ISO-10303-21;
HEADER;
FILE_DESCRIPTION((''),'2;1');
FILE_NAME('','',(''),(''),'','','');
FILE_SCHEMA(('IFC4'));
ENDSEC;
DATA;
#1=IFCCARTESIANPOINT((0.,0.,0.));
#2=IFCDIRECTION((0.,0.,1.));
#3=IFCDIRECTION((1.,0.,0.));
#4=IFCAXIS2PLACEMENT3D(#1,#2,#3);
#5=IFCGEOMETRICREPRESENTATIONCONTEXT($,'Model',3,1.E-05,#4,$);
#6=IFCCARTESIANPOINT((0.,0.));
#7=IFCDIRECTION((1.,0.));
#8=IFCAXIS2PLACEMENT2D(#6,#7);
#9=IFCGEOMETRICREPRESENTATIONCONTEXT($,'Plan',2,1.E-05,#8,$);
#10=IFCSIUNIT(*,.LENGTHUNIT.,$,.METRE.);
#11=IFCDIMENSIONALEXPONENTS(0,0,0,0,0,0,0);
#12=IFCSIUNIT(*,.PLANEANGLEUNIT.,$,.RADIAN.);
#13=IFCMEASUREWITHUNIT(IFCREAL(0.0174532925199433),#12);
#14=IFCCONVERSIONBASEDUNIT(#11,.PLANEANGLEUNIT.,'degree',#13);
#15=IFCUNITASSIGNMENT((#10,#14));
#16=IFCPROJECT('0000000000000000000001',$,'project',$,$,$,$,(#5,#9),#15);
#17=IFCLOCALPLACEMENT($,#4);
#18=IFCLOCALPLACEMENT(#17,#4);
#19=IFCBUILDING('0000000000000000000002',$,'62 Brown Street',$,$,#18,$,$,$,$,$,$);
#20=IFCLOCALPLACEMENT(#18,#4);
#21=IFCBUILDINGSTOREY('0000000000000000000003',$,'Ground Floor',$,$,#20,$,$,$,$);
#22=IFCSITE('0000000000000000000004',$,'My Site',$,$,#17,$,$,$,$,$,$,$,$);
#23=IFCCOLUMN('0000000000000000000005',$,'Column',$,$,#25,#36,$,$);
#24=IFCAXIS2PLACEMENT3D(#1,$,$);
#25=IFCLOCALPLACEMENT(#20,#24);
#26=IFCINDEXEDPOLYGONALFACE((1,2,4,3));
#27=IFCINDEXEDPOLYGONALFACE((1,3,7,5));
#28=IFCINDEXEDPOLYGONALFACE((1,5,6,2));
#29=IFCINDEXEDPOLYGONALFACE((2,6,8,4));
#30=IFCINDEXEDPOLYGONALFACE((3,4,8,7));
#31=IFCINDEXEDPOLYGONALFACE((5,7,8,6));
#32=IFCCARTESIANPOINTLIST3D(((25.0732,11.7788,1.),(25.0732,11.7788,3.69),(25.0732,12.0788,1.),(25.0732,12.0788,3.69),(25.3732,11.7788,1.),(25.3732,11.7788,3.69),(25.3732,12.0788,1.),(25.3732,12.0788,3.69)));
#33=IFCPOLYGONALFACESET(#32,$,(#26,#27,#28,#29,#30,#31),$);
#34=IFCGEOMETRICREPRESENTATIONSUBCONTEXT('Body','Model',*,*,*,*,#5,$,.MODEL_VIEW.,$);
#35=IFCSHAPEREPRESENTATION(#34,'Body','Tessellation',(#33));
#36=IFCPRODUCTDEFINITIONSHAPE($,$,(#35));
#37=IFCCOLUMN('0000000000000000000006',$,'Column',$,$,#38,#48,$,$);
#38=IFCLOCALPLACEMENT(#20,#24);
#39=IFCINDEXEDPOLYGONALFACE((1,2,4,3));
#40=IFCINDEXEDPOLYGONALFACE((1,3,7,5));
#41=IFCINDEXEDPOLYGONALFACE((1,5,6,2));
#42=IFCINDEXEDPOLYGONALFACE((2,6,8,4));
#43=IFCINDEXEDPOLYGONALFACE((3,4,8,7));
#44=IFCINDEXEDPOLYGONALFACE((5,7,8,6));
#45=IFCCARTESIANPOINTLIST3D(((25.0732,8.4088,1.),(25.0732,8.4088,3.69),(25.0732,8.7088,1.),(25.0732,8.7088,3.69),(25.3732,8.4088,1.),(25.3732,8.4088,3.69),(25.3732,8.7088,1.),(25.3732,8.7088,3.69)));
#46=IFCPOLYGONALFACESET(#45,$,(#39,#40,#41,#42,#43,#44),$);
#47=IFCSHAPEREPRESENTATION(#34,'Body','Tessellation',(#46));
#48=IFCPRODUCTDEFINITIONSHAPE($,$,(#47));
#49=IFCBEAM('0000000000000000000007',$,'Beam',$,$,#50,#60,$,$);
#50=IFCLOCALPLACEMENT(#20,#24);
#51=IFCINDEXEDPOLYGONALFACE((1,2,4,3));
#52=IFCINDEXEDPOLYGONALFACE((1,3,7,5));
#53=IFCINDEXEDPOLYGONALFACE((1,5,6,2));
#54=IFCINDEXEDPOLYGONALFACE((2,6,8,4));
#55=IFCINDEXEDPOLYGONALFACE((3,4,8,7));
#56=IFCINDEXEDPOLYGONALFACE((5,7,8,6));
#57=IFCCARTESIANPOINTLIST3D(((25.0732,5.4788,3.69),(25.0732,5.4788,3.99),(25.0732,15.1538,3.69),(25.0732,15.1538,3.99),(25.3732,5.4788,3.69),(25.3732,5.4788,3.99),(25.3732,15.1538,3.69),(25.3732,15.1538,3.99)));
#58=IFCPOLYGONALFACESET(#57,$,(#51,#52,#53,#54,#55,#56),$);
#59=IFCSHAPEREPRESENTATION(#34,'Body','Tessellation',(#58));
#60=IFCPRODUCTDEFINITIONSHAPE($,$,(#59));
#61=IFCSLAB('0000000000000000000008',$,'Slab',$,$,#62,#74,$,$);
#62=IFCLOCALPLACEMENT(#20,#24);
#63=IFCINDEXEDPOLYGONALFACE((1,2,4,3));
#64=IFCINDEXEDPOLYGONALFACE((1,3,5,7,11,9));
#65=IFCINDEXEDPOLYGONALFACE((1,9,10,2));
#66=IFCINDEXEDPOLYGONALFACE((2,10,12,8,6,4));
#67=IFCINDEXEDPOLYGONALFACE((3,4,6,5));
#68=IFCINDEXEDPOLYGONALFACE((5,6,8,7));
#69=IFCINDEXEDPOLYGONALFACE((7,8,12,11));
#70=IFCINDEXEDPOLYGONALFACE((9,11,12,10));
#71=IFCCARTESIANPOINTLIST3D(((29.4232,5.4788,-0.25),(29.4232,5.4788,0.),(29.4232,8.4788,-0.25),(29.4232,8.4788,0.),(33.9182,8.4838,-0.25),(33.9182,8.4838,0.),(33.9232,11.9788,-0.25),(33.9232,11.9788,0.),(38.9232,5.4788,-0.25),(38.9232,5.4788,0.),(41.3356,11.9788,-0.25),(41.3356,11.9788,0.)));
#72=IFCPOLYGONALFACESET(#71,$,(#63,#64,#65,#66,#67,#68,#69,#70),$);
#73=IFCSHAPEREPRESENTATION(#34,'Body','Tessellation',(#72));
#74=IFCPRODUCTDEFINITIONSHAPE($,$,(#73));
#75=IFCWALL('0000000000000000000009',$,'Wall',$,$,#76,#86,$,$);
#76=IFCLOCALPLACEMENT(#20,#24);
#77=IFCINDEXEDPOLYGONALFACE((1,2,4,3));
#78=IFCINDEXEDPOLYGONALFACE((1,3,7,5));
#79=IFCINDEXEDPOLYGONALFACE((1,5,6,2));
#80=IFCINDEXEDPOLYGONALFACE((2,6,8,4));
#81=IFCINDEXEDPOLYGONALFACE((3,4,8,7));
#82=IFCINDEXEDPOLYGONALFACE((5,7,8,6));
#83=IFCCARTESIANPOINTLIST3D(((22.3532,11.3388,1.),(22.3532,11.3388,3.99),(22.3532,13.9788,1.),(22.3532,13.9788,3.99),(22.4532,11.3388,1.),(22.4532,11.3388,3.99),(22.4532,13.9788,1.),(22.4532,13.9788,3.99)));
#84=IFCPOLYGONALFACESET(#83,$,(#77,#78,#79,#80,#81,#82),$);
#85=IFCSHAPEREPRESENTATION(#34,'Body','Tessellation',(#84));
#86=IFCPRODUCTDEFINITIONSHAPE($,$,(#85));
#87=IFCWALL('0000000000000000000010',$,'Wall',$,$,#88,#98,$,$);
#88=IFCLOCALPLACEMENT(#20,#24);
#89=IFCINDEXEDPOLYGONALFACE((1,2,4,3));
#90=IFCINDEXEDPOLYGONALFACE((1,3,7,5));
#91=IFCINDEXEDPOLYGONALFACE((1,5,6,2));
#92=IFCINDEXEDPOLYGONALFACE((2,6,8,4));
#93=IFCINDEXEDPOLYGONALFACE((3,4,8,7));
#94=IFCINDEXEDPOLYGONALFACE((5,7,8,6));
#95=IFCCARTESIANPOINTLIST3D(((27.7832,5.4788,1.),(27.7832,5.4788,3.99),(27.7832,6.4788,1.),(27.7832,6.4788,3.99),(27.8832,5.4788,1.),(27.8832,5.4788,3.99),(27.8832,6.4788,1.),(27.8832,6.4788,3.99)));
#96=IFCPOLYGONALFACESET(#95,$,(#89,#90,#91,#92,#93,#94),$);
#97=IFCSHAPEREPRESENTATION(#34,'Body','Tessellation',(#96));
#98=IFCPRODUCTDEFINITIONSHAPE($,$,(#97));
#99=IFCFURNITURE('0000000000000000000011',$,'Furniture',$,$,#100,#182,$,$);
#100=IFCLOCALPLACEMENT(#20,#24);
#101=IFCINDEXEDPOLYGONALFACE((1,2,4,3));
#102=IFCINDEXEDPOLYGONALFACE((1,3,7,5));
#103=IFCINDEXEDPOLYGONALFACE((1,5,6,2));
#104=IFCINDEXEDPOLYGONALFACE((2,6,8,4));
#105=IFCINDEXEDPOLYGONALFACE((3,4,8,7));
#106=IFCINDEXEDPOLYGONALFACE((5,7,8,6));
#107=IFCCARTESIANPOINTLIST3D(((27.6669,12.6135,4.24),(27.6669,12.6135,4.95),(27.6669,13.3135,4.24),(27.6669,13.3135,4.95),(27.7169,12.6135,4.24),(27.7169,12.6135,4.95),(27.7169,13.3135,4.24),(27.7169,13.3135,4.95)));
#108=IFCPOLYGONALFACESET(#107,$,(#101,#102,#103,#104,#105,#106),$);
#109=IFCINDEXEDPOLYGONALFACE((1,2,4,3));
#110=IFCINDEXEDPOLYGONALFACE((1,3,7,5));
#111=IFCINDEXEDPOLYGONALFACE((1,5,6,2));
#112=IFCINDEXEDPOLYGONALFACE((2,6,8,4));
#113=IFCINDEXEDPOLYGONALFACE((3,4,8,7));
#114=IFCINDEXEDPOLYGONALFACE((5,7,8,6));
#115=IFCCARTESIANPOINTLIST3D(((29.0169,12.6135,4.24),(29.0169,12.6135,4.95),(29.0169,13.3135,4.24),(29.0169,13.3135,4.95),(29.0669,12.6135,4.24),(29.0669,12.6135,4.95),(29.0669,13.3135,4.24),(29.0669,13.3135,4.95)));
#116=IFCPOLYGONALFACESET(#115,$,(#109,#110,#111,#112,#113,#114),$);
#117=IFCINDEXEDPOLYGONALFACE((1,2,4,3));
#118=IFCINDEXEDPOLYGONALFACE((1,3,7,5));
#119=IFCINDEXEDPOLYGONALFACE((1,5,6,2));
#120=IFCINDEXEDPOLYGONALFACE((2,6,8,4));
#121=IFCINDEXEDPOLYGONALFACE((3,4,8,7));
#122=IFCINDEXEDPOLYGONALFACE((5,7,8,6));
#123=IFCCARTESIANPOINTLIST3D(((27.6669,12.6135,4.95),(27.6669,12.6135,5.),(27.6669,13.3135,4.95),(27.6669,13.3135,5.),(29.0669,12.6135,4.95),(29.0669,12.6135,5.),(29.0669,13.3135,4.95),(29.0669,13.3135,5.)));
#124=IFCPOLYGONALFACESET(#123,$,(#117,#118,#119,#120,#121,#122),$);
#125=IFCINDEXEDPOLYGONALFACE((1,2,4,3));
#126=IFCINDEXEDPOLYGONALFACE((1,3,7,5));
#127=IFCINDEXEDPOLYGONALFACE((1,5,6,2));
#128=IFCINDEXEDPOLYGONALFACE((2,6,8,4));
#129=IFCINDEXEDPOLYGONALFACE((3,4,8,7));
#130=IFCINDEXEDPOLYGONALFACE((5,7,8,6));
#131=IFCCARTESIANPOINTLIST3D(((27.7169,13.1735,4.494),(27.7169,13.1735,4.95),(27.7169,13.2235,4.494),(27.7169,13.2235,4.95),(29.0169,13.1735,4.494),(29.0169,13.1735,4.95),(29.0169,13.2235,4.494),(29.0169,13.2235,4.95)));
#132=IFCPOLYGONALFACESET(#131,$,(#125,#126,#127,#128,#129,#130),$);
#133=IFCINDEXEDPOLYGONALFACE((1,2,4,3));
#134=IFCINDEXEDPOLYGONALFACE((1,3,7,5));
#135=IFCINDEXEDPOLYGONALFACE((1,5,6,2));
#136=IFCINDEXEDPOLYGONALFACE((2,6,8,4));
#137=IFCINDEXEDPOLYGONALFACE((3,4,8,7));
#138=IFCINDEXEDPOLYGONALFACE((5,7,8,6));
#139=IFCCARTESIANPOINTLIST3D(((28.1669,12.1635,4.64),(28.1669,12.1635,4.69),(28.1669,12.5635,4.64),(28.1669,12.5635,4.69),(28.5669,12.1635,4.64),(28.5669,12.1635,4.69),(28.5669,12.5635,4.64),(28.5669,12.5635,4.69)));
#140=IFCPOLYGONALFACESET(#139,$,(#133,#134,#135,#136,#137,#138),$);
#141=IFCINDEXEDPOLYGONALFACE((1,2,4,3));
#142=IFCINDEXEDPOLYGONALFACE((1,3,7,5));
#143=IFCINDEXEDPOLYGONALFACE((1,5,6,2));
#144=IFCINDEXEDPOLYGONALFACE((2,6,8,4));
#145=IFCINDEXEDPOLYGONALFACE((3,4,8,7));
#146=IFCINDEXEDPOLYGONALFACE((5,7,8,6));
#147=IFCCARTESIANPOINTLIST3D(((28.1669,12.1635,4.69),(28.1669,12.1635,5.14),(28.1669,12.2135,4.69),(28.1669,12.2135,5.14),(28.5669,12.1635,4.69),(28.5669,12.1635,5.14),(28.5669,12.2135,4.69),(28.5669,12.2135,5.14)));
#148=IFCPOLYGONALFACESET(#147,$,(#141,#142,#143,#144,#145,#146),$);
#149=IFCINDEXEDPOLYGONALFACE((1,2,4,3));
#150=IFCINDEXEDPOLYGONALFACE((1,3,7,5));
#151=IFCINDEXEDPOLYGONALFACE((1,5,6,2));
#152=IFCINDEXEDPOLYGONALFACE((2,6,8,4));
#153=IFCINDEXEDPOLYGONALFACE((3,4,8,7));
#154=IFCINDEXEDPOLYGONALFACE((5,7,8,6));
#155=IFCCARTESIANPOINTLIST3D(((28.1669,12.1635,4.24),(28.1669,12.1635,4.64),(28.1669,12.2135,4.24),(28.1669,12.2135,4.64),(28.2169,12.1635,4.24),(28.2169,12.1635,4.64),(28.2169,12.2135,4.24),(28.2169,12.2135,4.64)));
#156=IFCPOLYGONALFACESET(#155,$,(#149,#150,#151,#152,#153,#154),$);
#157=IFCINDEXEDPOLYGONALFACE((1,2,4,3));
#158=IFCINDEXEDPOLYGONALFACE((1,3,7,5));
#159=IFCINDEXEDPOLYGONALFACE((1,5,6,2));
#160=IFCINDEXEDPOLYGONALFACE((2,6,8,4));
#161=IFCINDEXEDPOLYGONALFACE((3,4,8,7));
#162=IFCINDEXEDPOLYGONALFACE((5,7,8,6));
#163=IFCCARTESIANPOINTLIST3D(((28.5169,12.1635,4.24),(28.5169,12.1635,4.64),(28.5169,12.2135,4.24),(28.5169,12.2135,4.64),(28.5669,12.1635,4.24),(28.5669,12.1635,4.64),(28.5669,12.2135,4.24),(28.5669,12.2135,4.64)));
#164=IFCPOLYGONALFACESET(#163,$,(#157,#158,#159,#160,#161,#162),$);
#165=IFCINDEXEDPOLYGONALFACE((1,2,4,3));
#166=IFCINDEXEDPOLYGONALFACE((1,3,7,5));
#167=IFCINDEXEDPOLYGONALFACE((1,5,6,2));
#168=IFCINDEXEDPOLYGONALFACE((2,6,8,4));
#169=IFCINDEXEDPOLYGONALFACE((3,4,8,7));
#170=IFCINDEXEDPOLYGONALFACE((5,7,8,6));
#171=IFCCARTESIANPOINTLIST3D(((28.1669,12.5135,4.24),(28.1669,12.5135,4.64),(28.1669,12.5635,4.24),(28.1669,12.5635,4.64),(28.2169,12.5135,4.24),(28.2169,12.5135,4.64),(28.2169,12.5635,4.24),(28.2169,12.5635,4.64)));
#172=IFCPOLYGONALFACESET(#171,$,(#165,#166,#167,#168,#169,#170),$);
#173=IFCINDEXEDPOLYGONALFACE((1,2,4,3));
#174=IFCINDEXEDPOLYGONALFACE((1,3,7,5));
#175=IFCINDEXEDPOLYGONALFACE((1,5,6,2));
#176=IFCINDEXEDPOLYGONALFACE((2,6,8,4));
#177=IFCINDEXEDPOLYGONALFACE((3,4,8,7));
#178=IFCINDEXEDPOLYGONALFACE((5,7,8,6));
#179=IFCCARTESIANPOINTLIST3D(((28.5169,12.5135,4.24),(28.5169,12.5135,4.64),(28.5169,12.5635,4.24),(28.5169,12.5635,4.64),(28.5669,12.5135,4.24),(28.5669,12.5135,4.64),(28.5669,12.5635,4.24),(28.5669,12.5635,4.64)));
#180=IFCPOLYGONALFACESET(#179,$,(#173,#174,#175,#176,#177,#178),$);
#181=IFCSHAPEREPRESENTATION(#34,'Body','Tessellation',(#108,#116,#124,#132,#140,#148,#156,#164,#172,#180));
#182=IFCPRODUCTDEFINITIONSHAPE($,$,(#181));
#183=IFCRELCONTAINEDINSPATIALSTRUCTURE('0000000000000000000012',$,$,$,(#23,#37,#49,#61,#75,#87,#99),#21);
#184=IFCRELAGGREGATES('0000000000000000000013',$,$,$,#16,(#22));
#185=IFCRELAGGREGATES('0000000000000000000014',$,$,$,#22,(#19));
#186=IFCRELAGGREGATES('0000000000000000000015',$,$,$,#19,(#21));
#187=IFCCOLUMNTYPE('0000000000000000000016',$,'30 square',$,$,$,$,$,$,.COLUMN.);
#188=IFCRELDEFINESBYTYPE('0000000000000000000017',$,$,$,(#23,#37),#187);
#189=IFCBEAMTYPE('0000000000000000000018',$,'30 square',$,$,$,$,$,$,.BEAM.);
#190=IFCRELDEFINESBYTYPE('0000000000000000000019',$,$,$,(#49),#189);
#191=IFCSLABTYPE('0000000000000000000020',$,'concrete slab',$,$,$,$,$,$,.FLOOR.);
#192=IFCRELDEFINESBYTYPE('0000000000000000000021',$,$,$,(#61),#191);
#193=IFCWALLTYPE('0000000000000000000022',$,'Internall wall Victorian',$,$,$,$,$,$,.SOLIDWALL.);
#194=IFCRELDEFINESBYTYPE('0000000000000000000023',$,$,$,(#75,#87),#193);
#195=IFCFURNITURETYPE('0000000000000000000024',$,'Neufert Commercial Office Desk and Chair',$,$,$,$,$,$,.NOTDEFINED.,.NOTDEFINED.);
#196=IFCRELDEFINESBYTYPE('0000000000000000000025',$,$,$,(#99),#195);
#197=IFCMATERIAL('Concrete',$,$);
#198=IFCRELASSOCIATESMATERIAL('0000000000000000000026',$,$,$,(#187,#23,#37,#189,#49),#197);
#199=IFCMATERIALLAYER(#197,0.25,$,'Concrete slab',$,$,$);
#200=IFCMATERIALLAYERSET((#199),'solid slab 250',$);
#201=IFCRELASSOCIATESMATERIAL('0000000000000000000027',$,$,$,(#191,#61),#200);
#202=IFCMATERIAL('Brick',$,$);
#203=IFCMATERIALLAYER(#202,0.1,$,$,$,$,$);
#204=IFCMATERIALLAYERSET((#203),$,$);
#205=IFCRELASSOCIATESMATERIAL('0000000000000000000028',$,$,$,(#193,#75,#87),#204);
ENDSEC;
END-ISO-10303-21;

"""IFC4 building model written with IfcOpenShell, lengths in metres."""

from ifc_helpers import new_model, entity, si_unit, converted_unit, frame, origin_with_axes, origin_2d_with_axis, place, context, subcontext, project, spatial, line, indexed_curve, rectangle, outline, extrude, shape, source, transform, mapped, material, layer, layer_set, layer_usage, material_profile, profile_set, profile_usage, type_object, type_shapes, element, save


model = new_model("IFC4")

# Units and contexts
model_context = context("Model", 3, precision=1e-05, world=origin_with_axes())
plan_context = context("Plan", 2, precision=1e-05, world=origin_2d_with_axis())
body_context_1 = subcontext(model_context, "Body", "Model", "MODEL_VIEW")
body_context_2 = subcontext(plan_context, "Body", "Plan", "PLAN_VIEW")
ifc_project = project(units=[si_unit("LENGTHUNIT", "METRE"), converted_unit("PLANEANGLEUNIT", "degree", entity("IfcReal", 0.0174532925199433), si_unit("PLANEANGLEUNIT", "RADIAN"), dimensions=[0, 0, 0, 0, 0, 0, 0])], contexts=[model_context, plan_context])

# Site, building, storey
site_placement = place(None, origin_with_axes())
site = spatial("IfcSite", under=ifc_project, at=site_placement, Name="My Site")
building_placement = place(site_placement, origin_with_axes())
building = spatial("IfcBuilding", under=site, at=building_placement, Name="62 Brown Street")
storey_placement = place(building_placement, origin_with_axes())
storey = spatial("IfcBuildingStorey", under=building, at=storey_placement, Name="Ground Floor")

# Columns
ifc_material_1 = material(Name="Concrete")
ifc_material_profile_1 = material_profile(ifc_material_1, rectangle(XDim=0.3, YDim=0.3))
ifc_profile_set_1 = profile_set([ifc_material_profile_1])
ifc_profile_usage_1 = profile_usage(ifc_profile_set_1, cardinal=5)
column_type = type_object("IfcColumnType", Name="30 square", PredefinedType="COLUMN", material=ifc_profile_set_1)
column_1_placement = place(storey_placement, frame((25.2232, 11.9288, 1.0), z_axis=(0.0, 0.0, 1.0), x_axis=(1.0, 0.0, 0.0)))
element("IfcColumn", 1, at=column_1_placement, inside=storey, type_object=column_type, material=ifc_profile_usage_1, Name="Column", context=body_context_1, shape_type="SweptSolid", body=[
    extrude(rectangle(XDim=0.3, YDim=0.3), origin_with_axes(), (0.0, 0.0, 1.0), 2.69),
])
ifc_profile_usage_2 = profile_usage(ifc_profile_set_1, cardinal=5)
column_2_placement = place(storey_placement, frame((25.2232, 8.5588, 1.0), z_axis=(0.0, 0.0, 1.0), x_axis=(1.0, 0.0, 0.0)))
element("IfcColumn", 2, at=column_2_placement, inside=storey, type_object=column_type, material=ifc_profile_usage_2, Name="Column", context=body_context_1, shape_type="SweptSolid", body=[
    extrude(rectangle(XDim=0.3, YDim=0.3), origin_with_axes(), (0.0, 0.0, 1.0), 2.69),
])

# Beam
ifc_material_profile_2 = material_profile(ifc_material_1, rectangle(XDim=0.3, YDim=0.3))
ifc_profile_set_2 = profile_set([ifc_material_profile_2])
ifc_profile_usage_3 = profile_usage(ifc_profile_set_2, cardinal=5)
beam_type = type_object("IfcBeamType", Name="30 square", PredefinedType="BEAM", material=ifc_profile_set_2)
beam_placement = place(storey_placement, frame((25.2232, 5.4788, 3.84), z_axis=(0.0, 1.0, 0.0), x_axis=(-1.0, 0.0, 0.0)))
element("IfcBeam", 3, at=beam_placement, inside=storey, type_object=beam_type, material=ifc_profile_usage_3, Name="Beam", context=body_context_1, shape_type="SweptSolid", body=[
    extrude(rectangle(XDim=0.3, YDim=0.3), origin_with_axes(), (0.0, 0.0, 1.0), 9.675),
])

# Slab
ifc_layer_1 = layer(ifc_material_1, 0.25, Name="Concrete slab")
ifc_layer_set_1 = layer_set([ifc_layer_1], Name="solid slab 250")
ifc_layer_usage_1 = layer_usage(ifc_layer_set_1, "AXIS3", "POSITIVE", 0.0)
slab_type = type_object("IfcSlabType", Name="concrete slab", PredefinedType="FLOOR", material=ifc_layer_set_1)
slab_1_placement = place(storey_placement, frame((29.4232, 5.4788, -0.25), z_axis=(0.0, 0.0, 1.0), x_axis=(1.0, 0.0, 0.0)))
element("IfcSlab", 4, at=slab_1_placement, inside=storey, type_object=slab_type, material=ifc_layer_usage_1, Name="Slab", context=body_context_1, shape_type="SweptSolid", body=[
    extrude(outline(indexed_curve([(0.0, 0.0), (9.5, 0.0), (11.9124, 6.5), (0.0, 3.0), (4.5, 6.5), (4.495, 3.005)], segments=[line(1, 2), line(2, 3), line(3, 5), line(5, 6), line(6, 4), line(4, 1)], self_intersect=False)), None, (0.0, 0.0, 1.0), 0.25),
])

# Walls
ifc_material_2 = material(Name="Brick")
ifc_layer_2 = layer(ifc_material_2, 0.1)
ifc_layer_set_2 = layer_set([ifc_layer_2])
ifc_layer_usage_2 = layer_usage(ifc_layer_set_2, "AXIS2", "POSITIVE", 0.0)
wall_type_1 = type_object("IfcWallType", Name="Internall wall Victorian", PredefinedType="SOLIDWALL", material=ifc_layer_set_2)
wall_1_placement = place(storey_placement, frame((22.4532, 11.3388, 1.0), z_axis=(0.0, 0.0, 1.0), x_axis=(0.0, 1.0, 0.0)))
element("IfcWall", 5, at=wall_1_placement, inside=storey, type_object=wall_type_1, material=ifc_layer_usage_2, Name="Wall", context=body_context_1, shape_type="SweptSolid", body=[
    extrude(outline(indexed_curve([(0.0, 0.0), (0.0, 0.1), (2.64, 0.1), (2.64, 0.0), (0.0, 0.0)], self_intersect=False)), origin_with_axes(), (0.0, 0.0, 1.0), 2.99),
])
ifc_layer_usage_3 = layer_usage(ifc_layer_set_2, "AXIS2", "POSITIVE", 0.0)
wall_2_placement = place(storey_placement, frame((27.8832, 5.4788, 1.0), z_axis=(0.0, 0.0, 1.0), x_axis=(0.0, 1.0, 0.0)))
element("IfcWall", 6, at=wall_2_placement, inside=storey, type_object=wall_type_1, material=ifc_layer_usage_3, Name="Wall", context=body_context_1, shape_type="SweptSolid", body=[
    extrude(outline(indexed_curve([(0.0, 0.0), (0.0, 0.1), (1.0, 0.1), (1.0, 0.0), (0.0, 0.0)], self_intersect=False)), origin_with_axes(), (0.0, 0.0, 1.0), 2.99),
])

# Furniture
furniture_type_1 = type_object("IfcFurnitureType", Name="Neufert Commercial Office Desk and Chair", AssemblyPlace="NOTDEFINED", PredefinedType="NOTDEFINED")
shared_shape_1 = source(origin_with_axes(), body_context_1, "Body", "SweptSolid", [
    extrude(outline(indexed_curve([(0.0, 0.0), (0.05, 0.0), (0.05, 0.7), (0.0, 0.7)], segments=[line(1, 2, 3, 4, 1)])), frame((0.0, 0.45, 0.0), z_axis=(0.0, 0.0, 1.0), x_axis=(1.0, 0.0, 0.0)), (0.0, 0.0, 1.0), 0.71),
    extrude(outline(indexed_curve([(0.0, 0.0), (0.05, 0.0), (0.05, 0.7), (0.0, 0.7)], segments=[line(1, 2, 3, 4, 1)])), frame((1.35, 0.45, 0.0), z_axis=(0.0, 0.0, 1.0), x_axis=(1.0, 0.0, 0.0)), (0.0, 0.0, 1.0), 0.71),
    extrude(outline(indexed_curve([(0.0, 0.0), (1.4, 0.0), (1.4, 0.7), (0.0, 0.7)], segments=[line(1, 2, 3, 4, 1)])), frame((0.0, 0.45, 0.71), z_axis=(0.0, 0.0, 1.0), x_axis=(1.0, 0.0, 0.0)), (0.0, 0.0, 1.0), 0.05),
    extrude(outline(indexed_curve([(0.05, 0.56), (1.35, 0.56), (1.35, 0.61), (0.05, 0.61)], segments=[line(1, 2, 3, 4, 1)])), frame((0.0, 0.45, 0.254), z_axis=(0.0, 0.0, 1.0), x_axis=(1.0, 0.0, 0.0)), (0.0, 0.0, 1.0), 0.456),
    extrude(outline(indexed_curve([(-0.2, 0.0), (0.2, 0.0), (0.2, 0.4), (-0.2, 0.4)], segments=[line(1, 2, 3, 4, 1)])), frame((0.7, 0.0, 0.45), z_axis=(0.0, 0.0, 1.0), x_axis=(1.0, 0.0, 0.0)), (0.0, 0.0, -1.0), 0.05),
    extrude(outline(indexed_curve([(-0.2, 0.0), (0.2, 0.0), (0.2, 0.05), (-0.2, 0.05)], segments=[line(1, 2, 3, 4, 1)])), frame((0.7, 0.0, 0.9), z_axis=(0.0, 0.0, 1.0), x_axis=(1.0, 0.0, 0.0)), (0.0, 0.0, -1.0), 0.45),
    extrude(outline(indexed_curve([(-0.2, 0.0), (-0.15, 0.0), (-0.15, 0.05), (-0.2, 0.05)], segments=[line(1, 2, 3, 4, 1)])), frame((0.7, 0.0, 0.0), z_axis=(0.0, 0.0, 1.0), x_axis=(1.0, 0.0, 0.0)), (0.0, 0.0, 1.0), 0.4),
    extrude(outline(indexed_curve([(0.2, 0.0), (0.15, 0.0), (0.15, 0.05), (0.2, 0.05)], segments=[line(1, 2, 3, 4, 1)])), frame((0.7, 0.0, 0.0), z_axis=(0.0, 0.0, 1.0), x_axis=(1.0, 0.0, 0.0)), (0.0, 0.0, 1.0), 0.4),
    extrude(outline(indexed_curve([(-0.2, 0.4), (-0.15, 0.4), (-0.15, 0.35), (-0.2, 0.35)], segments=[line(1, 2, 3, 4, 1)])), frame((0.7, 0.0, 0.0), z_axis=(0.0, 0.0, 1.0), x_axis=(1.0, 0.0, 0.0)), (0.0, 0.0, 1.0), 0.4),
    extrude(outline(indexed_curve([(0.2, 0.4), (0.15, 0.4), (0.15, 0.35), (0.2, 0.35)], segments=[line(1, 2, 3, 4, 1)])), frame((0.7, 0.0, 0.0), z_axis=(0.0, 0.0, 1.0), x_axis=(1.0, 0.0, 0.0)), (0.0, 0.0, 1.0), 0.4),
])
shared_shape_2 = source(origin_with_axes(), body_context_2, "Body", "Curve2D", [
    entity("IfcIndexedPolyCurve", entity("IfcCartesianPointList2D", [[0.0, 0.45], [1.4, 0.45], [1.4, 1.15], [0.0, 1.15]]), [entity("IfcLineIndex", [1, 2, 3, 4, 1])]),
    entity("IfcIndexedPolyCurve", entity("IfcCartesianPointList2D", [[0.5, 0.4], [0.9, 0.4]])),
    entity("IfcIndexedPolyCurve", entity("IfcCartesianPointList2D", [[0.5, 0.4], [0.5, 0.2], [0.5586, 0.0586], [0.7, 0.0], [0.8414, 0.0586], [0.9, 0.2], [0.9, 0.4]]), [entity("IfcLineIndex", [1, 2]), entity("IfcArcIndex", [2, 3, 4]), entity("IfcArcIndex", [4, 5, 6]), entity("IfcLineIndex", [6, 7])]),
    entity("IfcIndexedPolyCurve", entity("IfcCartesianPointList2D", [[0.54, 0.4], [0.54, 0.2], [0.5869, 0.0869], [0.7, 0.04], [0.8131, 0.0869], [0.86, 0.2], [0.86, 0.4]]), [entity("IfcLineIndex", [1, 2]), entity("IfcArcIndex", [2, 3, 4]), entity("IfcArcIndex", [4, 5, 6]), entity("IfcLineIndex", [6, 7])]),
])
type_shapes(furniture_type_1, [shared_shape_1, shared_shape_2])
for number, where, z_axis, x_axis, name in (
    (7, (27.6669, 12.1635, 4.24), (0.0, 0.0, 1.0), (1.0, 0.0, 0.0), "Furniture"),
):
    element("IfcFurniture", number, at=place(storey_placement, frame(where, z_axis=z_axis, x_axis=x_axis)), inside=storey, type_object=furniture_type_1, Name=name, shapes=[
        shape(body_context_1, "Body", "MappedRepresentation", [mapped(shared_shape_1, transform((0.0, 0.0, 0.0), x_axis=(1.0, 0.0, 0.0), y_axis=(0.0, 1.0, 0.0), z_axis=(0.0, 0.0, 1.0), scale=1.0))]),
        shape(body_context_2, "Body", "MappedRepresentation", [mapped(shared_shape_2, transform((0.0, 0.0, 0.0), x_axis=(1.0, 0.0, 0.0), y_axis=(0.0, 1.0, 0.0), z_axis=(0.0, 0.0, 1.0), scale=1.0))]),
    ])

save(model, "model.ifc")
